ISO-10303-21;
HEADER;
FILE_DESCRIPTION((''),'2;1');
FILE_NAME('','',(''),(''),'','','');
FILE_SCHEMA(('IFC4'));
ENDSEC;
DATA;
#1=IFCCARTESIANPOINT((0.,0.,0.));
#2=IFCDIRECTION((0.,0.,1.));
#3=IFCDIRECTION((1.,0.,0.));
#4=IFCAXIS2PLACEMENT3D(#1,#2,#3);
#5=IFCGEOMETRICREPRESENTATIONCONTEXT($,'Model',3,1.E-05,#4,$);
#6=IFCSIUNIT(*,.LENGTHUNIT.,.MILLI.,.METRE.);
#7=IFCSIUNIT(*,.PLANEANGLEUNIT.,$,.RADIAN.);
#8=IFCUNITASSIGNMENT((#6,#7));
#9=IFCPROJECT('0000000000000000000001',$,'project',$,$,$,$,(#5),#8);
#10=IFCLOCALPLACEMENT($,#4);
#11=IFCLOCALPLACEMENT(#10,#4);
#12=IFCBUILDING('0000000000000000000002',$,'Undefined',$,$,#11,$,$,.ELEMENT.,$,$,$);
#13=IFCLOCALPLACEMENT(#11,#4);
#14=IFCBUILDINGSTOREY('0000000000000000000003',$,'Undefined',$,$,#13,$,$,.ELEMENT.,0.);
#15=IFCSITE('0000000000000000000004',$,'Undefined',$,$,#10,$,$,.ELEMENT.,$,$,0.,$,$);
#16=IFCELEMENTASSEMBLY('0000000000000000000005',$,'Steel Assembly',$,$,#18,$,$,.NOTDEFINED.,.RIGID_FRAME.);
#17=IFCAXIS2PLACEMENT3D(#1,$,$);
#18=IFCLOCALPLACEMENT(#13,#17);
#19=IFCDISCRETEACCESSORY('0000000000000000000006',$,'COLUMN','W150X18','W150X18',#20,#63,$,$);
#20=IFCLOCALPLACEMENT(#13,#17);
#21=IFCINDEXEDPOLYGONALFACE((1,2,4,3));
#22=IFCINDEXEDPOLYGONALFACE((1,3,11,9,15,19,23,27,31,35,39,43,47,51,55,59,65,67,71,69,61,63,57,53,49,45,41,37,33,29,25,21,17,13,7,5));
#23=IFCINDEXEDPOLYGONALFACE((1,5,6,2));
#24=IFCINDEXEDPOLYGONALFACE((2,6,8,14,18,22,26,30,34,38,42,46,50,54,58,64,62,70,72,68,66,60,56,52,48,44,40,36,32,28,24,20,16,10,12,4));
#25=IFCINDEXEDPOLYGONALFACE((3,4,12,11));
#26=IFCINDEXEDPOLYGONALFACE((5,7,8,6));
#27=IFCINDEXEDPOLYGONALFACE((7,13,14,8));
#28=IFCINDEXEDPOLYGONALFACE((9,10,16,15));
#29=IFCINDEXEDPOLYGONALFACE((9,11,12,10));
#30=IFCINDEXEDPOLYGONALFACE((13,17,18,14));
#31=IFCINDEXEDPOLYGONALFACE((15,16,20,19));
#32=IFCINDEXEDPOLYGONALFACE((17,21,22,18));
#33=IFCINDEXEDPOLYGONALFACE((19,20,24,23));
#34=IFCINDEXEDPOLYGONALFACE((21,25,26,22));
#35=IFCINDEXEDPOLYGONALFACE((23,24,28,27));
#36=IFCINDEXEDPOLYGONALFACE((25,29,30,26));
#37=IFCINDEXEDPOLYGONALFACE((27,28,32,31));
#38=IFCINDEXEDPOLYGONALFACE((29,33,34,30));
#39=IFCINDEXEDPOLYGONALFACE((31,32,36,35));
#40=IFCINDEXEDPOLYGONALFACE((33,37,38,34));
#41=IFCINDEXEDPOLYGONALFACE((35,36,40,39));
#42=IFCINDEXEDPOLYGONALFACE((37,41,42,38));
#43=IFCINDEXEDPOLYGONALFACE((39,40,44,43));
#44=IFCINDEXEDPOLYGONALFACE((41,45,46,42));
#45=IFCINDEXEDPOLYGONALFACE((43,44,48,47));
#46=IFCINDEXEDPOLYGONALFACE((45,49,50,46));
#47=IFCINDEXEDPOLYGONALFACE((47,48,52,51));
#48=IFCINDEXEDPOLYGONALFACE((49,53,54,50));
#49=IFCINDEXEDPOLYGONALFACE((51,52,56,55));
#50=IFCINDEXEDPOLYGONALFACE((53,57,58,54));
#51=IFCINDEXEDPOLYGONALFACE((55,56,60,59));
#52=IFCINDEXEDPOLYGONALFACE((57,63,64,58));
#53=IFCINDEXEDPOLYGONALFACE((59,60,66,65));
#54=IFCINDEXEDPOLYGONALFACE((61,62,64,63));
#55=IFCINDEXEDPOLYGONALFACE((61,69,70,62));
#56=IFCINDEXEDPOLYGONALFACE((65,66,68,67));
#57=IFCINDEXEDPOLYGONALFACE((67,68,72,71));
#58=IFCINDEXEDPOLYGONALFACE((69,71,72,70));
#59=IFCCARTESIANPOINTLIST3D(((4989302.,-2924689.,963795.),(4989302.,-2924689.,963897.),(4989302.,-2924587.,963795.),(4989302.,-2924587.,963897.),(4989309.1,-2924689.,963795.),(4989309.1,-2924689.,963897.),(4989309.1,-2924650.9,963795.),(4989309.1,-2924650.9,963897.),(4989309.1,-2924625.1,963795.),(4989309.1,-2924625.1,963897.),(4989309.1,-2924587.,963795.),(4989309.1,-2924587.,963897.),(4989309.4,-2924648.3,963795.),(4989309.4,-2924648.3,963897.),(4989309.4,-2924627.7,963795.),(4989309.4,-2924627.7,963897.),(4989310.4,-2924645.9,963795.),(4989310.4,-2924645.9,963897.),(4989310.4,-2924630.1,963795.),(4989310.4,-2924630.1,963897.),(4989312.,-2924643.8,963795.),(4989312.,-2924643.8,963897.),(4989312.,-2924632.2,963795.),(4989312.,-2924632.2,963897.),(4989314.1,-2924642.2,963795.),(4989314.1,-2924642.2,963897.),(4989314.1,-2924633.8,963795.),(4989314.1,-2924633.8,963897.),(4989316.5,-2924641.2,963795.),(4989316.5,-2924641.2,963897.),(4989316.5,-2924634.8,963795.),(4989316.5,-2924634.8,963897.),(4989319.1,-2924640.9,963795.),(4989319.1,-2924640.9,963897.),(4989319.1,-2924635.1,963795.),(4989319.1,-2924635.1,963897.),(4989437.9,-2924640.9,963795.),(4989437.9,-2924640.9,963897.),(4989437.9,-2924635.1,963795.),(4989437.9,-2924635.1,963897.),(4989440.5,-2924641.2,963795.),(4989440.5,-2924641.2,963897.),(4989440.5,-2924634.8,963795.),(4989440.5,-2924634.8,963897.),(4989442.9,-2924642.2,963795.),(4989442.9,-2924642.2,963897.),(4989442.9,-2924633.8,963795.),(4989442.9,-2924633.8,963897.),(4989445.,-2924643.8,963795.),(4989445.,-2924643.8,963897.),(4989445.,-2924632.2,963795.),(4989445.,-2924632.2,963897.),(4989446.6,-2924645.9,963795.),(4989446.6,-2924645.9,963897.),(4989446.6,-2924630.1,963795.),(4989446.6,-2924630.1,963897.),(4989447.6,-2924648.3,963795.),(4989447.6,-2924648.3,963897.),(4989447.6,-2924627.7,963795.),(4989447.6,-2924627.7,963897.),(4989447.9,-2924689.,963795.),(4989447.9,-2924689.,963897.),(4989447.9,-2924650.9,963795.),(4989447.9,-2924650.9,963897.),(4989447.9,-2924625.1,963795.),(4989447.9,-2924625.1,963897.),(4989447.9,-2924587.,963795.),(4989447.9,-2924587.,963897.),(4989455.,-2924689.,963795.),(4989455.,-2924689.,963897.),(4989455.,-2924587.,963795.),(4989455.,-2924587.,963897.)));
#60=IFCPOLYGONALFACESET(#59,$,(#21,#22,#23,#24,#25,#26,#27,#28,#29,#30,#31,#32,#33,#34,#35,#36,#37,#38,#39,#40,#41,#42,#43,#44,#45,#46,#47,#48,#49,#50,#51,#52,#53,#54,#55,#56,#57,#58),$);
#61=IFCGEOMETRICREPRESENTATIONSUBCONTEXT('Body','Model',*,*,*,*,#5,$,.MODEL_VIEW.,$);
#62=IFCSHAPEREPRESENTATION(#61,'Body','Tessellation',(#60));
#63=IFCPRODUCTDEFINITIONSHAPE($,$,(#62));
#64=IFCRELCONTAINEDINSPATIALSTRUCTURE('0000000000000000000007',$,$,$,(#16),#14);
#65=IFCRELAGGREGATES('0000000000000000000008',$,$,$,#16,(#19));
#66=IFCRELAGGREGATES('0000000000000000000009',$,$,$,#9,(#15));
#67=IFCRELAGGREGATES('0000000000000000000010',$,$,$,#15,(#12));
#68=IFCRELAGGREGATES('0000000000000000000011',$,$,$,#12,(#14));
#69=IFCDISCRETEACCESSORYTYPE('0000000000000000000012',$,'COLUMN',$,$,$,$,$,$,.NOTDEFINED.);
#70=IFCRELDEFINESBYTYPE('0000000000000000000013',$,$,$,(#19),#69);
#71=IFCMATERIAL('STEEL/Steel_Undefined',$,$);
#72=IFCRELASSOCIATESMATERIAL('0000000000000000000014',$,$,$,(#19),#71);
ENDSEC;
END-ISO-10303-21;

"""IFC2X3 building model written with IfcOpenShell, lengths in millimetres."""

from ifc_helpers import new_model, si_unit, frame, origin_with_axes, origin_2d_with_axis, place, context, subcontext, project, spatial, i_section, extrude, material, type_object, element, aggregate, save


model = new_model("IFC2X3")

# Units and contexts
model_context = context("Model", 3, precision=1e-05, world=origin_with_axes())
body_context = subcontext(model_context, "Body", "Model", "MODEL_VIEW")
ifc_project = project(units=[si_unit("LENGTHUNIT", "METRE", prefix="MILLI"), si_unit("PLANEANGLEUNIT", "RADIAN")], contexts=[model_context])

# Site, building, storey
site_placement = place(None, origin_with_axes())
site = spatial("IfcSite", under=ifc_project, at=site_placement, Name="Undefined", CompositionType="ELEMENT", RefElevation=0.0)
building_placement = place(site_placement, origin_with_axes())
building = spatial("IfcBuilding", under=site, at=building_placement, Name="Undefined", CompositionType="ELEMENT")
storey_placement = place(building_placement, origin_with_axes())
storey = spatial("IfcBuildingStorey", under=building, at=storey_placement, Name="Undefined", CompositionType="ELEMENT", Elevation=0.0)

# Element assembly
assembly_1_placement = place(storey_placement, origin_with_axes())
assembly_1 = element("IfcElementAssembly", 1, at=assembly_1_placement, inside=storey, Name="Steel Assembly", AssemblyPlace="NOTDEFINED", PredefinedType="RIGID_FRAME")

# Discrete accessory
ifc_material_1 = material(Name="STEEL/Steel_Undefined")
discrete_accessory_type_1 = type_object("IfcDiscreteAccessoryType", Name="COLUMN")
discrete_accessory_1_placement = place(assembly_1_placement, frame((4989378.5, -2924638.0, 963795.0), z_axis=(0.0, 0.0, 1.0), x_axis=(-1.0, 0.0, 0.0)))
discrete_accessory_1 = element("IfcDiscreteAccessory", 2, at=discrete_accessory_1_placement, type_object=discrete_accessory_type_1, material=ifc_material_1, Name="COLUMN", Description="W150X18", ObjectType="W150X18", context=body_context, shape_type="SweptSolid", body=[
    extrude(i_section(OverallWidth=102.0, OverallDepth=153.0, WebThickness=5.8, FlangeThickness=7.1, FilletRadius=10.0, at=origin_2d_with_axis()), frame((0.0, 0.0, 102.0), z_axis=(0.0, 0.0, -1.0), x_axis=(0.0, 1.0, 0.0)), (0.0, 0.0, 1.0), 102.0),
])
aggregate(assembly_1, [discrete_accessory_1])

save(model, "model.ifc")
